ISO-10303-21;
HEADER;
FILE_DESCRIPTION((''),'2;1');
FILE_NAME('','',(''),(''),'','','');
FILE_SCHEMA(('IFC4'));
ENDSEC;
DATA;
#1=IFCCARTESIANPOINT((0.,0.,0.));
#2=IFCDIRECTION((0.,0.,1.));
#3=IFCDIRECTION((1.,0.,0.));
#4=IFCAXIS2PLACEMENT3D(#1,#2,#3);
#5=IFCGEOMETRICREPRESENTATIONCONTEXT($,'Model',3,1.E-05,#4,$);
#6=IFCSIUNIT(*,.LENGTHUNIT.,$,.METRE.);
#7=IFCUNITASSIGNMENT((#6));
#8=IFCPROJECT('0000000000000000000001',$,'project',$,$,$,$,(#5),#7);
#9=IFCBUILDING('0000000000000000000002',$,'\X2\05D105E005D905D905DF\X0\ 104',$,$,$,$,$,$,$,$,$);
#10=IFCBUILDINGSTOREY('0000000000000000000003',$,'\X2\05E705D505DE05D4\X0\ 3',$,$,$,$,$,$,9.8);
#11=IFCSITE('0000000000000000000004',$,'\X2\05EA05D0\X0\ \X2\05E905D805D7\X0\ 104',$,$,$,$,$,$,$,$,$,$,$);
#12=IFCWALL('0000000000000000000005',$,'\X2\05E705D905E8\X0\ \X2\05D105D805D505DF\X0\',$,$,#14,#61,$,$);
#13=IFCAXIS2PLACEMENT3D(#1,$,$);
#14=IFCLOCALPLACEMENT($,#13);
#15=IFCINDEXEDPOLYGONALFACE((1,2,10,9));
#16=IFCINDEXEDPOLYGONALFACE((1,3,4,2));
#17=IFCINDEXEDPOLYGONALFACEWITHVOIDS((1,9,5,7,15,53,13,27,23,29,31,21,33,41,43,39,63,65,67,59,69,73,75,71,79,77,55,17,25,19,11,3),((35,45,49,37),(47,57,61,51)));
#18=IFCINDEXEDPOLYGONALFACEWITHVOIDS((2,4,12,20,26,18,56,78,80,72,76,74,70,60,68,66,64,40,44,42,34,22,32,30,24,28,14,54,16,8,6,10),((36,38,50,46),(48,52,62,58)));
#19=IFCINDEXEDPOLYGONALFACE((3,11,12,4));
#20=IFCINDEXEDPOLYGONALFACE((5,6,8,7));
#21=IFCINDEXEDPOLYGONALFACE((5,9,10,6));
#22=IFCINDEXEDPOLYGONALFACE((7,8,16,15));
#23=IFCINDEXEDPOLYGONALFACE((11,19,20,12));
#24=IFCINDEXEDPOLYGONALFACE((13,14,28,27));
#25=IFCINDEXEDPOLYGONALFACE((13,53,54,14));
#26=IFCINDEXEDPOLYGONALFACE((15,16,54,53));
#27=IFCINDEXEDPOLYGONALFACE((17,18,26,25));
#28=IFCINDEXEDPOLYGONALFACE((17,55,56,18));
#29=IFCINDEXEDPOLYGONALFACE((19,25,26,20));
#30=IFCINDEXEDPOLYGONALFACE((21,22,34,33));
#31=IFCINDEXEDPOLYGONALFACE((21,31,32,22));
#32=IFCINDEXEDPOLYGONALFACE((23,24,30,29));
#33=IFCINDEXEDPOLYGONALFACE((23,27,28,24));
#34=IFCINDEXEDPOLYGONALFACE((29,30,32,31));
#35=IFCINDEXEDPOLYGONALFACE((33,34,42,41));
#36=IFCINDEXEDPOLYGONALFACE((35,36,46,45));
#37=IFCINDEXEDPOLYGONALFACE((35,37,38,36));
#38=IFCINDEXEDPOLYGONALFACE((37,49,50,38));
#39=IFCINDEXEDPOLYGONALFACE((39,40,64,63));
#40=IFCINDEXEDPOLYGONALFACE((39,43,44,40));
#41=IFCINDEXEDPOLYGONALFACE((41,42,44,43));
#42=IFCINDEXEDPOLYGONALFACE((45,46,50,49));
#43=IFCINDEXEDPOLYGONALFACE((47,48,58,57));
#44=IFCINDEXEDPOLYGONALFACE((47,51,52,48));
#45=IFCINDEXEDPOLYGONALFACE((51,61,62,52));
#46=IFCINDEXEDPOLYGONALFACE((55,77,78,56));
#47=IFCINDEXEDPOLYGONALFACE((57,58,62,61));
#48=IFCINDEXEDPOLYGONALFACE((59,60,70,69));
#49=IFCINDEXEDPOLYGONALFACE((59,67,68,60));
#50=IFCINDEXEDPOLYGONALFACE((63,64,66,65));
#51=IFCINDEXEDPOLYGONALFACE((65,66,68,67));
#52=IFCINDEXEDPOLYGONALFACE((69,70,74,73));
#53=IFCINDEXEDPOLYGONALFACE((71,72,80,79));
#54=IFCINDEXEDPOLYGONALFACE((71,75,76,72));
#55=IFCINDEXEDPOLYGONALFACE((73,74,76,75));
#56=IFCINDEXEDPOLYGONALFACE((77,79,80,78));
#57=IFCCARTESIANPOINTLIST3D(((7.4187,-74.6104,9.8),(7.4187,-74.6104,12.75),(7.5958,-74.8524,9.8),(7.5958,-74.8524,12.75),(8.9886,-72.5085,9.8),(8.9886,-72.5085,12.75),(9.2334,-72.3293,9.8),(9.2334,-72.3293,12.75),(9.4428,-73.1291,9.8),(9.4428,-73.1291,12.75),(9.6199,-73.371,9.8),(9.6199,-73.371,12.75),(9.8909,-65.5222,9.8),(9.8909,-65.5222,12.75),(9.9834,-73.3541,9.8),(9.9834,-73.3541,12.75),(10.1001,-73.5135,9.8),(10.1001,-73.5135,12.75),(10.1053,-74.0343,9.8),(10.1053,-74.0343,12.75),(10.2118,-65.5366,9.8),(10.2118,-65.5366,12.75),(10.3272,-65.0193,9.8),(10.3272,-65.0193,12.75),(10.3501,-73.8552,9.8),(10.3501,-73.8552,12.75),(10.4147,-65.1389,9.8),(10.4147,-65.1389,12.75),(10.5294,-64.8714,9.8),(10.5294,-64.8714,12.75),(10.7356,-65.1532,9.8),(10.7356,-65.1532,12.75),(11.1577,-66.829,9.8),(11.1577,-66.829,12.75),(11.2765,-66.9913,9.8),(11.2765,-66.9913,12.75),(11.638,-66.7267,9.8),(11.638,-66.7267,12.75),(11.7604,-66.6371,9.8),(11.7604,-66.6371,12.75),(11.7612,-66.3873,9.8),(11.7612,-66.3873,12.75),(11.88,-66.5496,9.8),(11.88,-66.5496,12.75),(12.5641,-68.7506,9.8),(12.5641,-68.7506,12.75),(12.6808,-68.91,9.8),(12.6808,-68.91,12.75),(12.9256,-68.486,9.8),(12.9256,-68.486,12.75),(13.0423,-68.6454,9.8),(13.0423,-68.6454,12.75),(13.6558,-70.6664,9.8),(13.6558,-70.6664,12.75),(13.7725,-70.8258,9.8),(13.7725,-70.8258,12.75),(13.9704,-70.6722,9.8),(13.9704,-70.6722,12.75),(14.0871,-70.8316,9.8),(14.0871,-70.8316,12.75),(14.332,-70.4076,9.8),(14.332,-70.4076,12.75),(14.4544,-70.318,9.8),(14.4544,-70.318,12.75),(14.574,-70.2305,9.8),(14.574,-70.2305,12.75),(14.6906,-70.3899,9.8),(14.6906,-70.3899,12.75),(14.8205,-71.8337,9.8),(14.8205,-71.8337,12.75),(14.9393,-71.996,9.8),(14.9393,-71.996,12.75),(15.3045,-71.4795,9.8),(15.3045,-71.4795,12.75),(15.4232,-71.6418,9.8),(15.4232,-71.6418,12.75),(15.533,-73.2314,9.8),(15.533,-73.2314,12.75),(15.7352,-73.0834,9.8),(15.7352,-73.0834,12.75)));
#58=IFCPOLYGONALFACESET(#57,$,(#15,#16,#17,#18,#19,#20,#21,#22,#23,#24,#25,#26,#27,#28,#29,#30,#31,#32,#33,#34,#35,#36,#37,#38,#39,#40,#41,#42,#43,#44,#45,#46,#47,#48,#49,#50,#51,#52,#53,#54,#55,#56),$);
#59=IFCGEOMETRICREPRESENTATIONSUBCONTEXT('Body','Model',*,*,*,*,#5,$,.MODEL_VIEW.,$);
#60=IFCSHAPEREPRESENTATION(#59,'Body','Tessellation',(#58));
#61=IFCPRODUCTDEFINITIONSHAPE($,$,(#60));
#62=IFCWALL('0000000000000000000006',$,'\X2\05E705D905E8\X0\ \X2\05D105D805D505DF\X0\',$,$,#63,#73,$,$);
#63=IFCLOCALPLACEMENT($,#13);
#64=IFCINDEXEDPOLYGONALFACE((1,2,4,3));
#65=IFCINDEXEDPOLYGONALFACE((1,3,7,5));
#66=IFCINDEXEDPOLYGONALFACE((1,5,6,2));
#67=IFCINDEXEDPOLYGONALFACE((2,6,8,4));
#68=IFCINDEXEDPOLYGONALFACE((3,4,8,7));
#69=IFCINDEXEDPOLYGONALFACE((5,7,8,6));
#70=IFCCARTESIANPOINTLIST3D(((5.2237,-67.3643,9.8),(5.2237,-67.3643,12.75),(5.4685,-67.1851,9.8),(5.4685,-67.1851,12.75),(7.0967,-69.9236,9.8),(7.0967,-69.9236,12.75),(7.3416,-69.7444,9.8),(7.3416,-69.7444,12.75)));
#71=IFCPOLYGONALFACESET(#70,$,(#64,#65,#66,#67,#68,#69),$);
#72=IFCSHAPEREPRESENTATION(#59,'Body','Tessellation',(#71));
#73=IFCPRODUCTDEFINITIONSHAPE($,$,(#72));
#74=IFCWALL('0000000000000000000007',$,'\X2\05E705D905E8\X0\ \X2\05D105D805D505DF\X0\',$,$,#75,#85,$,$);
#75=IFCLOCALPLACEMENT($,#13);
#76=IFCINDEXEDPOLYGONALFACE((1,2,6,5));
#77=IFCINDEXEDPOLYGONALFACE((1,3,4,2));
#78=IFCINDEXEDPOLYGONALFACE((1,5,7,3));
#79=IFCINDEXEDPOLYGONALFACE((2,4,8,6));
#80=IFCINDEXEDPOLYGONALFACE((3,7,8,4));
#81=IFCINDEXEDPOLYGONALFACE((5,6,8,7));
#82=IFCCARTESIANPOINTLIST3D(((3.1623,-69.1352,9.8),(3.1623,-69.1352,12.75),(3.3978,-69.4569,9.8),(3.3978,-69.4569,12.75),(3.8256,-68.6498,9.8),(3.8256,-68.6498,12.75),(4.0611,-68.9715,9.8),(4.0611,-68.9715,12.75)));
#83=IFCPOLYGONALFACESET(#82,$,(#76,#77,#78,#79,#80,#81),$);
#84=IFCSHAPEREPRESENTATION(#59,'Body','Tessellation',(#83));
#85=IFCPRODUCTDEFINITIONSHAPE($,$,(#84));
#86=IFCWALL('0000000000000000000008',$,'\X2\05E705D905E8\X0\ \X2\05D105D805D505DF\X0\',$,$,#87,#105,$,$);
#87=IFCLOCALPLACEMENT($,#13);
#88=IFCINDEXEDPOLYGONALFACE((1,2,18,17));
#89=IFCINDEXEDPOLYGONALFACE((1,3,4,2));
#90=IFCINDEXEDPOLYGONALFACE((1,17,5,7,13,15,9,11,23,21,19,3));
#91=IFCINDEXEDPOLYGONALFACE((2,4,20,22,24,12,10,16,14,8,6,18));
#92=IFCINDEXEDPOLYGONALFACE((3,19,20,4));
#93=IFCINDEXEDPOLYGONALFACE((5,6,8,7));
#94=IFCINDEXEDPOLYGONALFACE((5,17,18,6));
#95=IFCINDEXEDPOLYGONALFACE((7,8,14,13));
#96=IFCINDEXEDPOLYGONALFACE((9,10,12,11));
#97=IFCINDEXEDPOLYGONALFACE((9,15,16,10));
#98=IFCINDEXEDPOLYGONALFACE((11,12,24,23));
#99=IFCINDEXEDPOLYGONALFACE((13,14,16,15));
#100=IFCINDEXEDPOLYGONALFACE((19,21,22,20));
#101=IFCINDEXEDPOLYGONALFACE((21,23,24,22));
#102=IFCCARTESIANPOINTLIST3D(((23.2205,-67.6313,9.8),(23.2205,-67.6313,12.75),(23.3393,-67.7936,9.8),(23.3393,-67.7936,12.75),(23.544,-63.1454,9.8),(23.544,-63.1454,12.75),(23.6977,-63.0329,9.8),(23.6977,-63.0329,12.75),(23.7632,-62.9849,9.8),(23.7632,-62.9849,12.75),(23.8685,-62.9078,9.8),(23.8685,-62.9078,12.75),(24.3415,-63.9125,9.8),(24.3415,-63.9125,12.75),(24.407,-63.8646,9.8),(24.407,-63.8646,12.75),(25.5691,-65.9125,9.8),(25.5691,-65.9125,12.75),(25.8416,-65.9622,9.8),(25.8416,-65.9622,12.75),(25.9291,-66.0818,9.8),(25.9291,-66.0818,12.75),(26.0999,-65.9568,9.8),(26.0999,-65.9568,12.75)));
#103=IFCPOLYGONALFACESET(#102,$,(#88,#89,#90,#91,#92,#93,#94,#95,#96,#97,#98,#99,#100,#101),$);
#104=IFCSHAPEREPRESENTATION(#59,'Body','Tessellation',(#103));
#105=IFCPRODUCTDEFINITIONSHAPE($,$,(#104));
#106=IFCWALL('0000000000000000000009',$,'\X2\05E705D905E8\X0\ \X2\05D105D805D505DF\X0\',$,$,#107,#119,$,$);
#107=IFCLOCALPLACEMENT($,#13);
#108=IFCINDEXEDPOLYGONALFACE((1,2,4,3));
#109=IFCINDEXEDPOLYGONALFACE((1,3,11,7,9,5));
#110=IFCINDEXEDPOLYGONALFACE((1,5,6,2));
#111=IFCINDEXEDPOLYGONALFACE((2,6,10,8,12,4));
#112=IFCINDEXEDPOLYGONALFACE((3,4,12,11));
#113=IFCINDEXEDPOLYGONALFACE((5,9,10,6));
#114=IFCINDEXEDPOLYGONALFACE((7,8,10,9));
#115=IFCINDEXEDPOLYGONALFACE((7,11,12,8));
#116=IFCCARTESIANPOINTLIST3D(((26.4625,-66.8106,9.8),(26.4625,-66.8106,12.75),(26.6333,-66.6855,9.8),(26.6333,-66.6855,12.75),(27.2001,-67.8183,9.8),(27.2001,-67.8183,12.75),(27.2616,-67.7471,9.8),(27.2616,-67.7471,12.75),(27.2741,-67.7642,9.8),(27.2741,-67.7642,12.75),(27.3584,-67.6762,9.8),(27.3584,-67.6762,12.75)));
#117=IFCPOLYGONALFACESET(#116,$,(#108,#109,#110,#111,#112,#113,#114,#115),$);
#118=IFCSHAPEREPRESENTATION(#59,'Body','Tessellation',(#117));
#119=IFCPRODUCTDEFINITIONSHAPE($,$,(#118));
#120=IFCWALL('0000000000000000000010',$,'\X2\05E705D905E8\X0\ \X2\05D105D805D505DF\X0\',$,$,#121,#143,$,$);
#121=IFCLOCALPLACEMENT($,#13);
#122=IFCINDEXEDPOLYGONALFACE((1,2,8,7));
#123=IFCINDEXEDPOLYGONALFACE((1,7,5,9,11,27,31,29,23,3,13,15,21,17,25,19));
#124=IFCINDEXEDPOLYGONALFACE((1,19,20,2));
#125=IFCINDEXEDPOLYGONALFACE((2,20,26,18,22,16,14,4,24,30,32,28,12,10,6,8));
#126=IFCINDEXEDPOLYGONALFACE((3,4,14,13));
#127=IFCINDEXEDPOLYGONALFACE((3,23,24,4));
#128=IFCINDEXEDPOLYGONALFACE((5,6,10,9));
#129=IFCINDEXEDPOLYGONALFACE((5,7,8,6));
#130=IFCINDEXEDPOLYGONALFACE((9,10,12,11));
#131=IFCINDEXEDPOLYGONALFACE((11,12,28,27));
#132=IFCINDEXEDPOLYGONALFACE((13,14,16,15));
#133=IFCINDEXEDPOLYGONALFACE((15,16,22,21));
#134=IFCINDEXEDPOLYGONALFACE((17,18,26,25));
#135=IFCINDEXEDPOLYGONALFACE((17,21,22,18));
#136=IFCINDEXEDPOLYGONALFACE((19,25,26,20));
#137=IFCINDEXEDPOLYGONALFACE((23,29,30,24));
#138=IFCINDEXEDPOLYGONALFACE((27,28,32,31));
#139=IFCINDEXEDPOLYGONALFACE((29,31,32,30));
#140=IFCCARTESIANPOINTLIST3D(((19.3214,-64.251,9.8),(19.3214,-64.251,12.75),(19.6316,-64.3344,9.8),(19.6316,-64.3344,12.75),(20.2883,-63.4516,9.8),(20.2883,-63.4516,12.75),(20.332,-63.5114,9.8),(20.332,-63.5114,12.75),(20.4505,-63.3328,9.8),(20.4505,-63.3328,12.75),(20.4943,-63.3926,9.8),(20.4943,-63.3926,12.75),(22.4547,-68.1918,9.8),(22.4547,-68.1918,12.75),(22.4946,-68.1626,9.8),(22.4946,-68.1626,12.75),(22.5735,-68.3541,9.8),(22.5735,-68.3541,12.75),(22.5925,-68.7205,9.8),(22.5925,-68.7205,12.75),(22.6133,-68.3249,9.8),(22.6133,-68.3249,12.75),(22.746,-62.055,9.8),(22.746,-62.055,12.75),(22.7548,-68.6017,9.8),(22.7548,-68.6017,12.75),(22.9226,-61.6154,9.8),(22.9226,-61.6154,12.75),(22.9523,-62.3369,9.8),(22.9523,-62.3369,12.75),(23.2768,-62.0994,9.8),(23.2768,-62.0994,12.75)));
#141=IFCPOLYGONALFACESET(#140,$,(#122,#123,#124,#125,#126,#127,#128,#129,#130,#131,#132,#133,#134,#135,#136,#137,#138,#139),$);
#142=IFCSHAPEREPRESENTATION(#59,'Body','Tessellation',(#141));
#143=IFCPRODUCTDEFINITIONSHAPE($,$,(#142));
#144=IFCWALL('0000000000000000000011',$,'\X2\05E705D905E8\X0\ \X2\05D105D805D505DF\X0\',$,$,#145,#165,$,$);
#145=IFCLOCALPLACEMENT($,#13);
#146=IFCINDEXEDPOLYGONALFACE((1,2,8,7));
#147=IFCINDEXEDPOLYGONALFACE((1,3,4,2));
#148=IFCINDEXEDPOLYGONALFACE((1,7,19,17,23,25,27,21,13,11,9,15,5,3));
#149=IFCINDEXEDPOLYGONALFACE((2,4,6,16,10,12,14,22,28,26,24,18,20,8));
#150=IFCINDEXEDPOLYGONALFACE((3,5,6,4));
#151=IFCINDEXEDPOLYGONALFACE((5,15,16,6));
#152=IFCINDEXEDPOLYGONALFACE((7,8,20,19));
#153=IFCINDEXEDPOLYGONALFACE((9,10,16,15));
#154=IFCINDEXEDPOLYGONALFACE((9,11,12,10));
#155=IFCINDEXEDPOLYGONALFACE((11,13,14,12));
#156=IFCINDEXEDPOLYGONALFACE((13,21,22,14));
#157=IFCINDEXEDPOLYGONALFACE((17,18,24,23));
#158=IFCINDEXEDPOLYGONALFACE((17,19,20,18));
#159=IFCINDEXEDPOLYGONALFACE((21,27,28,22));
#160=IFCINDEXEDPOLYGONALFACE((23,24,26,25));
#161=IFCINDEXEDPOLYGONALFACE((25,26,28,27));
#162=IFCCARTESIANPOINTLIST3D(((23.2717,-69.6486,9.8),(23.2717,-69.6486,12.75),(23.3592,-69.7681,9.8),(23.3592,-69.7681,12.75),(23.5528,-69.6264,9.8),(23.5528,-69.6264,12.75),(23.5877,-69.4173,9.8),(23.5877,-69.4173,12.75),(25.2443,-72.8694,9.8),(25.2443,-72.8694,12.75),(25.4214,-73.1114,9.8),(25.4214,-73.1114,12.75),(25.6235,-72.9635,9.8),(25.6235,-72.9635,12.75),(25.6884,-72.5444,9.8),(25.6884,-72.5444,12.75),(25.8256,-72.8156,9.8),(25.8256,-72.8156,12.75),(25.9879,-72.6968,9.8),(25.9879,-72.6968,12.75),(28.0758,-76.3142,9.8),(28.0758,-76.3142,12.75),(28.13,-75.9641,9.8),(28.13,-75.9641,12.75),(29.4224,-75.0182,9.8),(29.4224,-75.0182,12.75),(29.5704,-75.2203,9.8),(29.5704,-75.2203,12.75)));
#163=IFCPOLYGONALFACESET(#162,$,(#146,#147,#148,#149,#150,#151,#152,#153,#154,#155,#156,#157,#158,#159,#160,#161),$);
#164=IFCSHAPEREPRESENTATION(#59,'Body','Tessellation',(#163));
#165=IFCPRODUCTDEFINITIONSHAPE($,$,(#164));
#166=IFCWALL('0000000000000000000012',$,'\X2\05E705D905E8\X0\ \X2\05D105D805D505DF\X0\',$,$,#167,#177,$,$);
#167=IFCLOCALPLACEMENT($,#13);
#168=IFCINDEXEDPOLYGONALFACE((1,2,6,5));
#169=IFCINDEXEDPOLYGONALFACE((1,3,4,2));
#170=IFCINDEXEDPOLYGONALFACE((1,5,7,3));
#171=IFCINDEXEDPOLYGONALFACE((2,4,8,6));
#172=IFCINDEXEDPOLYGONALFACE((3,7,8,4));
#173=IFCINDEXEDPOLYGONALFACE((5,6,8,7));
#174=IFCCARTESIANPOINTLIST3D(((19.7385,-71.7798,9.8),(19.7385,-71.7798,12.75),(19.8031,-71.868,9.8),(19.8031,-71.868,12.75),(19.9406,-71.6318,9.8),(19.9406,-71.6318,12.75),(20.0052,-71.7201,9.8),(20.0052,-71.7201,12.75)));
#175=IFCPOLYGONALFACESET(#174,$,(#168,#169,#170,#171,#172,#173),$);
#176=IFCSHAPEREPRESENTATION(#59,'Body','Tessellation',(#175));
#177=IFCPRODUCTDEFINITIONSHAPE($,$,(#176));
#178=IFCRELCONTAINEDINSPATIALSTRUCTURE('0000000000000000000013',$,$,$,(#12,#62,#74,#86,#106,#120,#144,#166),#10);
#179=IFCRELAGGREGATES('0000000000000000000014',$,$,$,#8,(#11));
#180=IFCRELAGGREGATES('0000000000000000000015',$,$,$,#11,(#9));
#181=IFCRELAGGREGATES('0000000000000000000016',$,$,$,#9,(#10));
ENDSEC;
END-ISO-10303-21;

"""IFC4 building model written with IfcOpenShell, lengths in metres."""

from ifc_helpers import new_model, si_unit, frame, origin_with_axes, context, subcontext, project, spatial, polyline, outline, extrude, element, save


model = new_model("IFC4")

# Units and contexts
model_context = context("Model", 3, precision=1e-05, world=origin_with_axes())
body_context = subcontext(model_context, "Body", "Model", "MODEL_VIEW")
ifc_project = project(units=[si_unit("LENGTHUNIT", "METRE")], contexts=[model_context])

# Site, building, storey
site = spatial("IfcSite", under=ifc_project, Name="תא שטח 104")
building = spatial("IfcBuilding", under=site, Name="בניין 104")
storey = spatial("IfcBuildingStorey", under=building, Name="קומה 3", Elevation=9.8)

# Walls
element("IfcWall", 1, inside=storey, Name="קיר בטון", context=body_context, shape_type="SweptSolid", body=[
    extrude(outline(polyline([(11.7604, -66.6371), (11.88, -66.5496), (11.7612, -66.3873), (11.1577, -66.829), (10.2118, -65.5366), (10.7356, -65.1532), (10.5294, -64.8714), (10.3272, -65.0193), (10.4147, -65.1389), (9.8909, -65.5222), (13.6558, -70.6664), (9.9834, -73.3541), (9.2334, -72.3293), (8.9886, -72.5085), (9.4428, -73.1291), (7.4187, -74.6104), (7.5958, -74.8524), (9.6199, -73.371), (10.1053, -74.0343), (10.3501, -73.8552), (10.1001, -73.5135), (13.7725, -70.8258), (15.533, -73.2314), (15.7352, -73.0834), (14.9393, -71.996), (15.4232, -71.6418), (15.3045, -71.4795), (14.8205, -71.8337), (14.0871, -70.8316), (14.6906, -70.3899), (14.574, -70.2305), (14.4544, -70.318), (11.7604, -66.6371)]), holes=[polyline([(11.638, -66.7267), (12.9256, -68.486), (12.5641, -68.7506), (11.2765, -66.9913), (11.638, -66.7267)]), polyline([(14.332, -70.4076), (13.9704, -70.6722), (12.6808, -68.91), (13.0423, -68.6454), (14.332, -70.4076)])]), frame((0.0, 0.0, 9.8)), (0.0, 0.0, 1.0), 2.95),
])
element("IfcWall", 2, inside=storey, Name="קיר בטון", context=body_context, shape_type="SweptSolid", body=[
    extrude(outline(polyline([(5.4685, -67.1851), (5.2237, -67.3643), (7.0967, -69.9236), (7.3416, -69.7444), (5.4685, -67.1851)])), frame((0.0, 0.0, 9.8)), (0.0, 0.0, 1.0), 2.95),
])
element("IfcWall", 3, inside=storey, Name="קיר בטון", context=body_context, shape_type="SweptSolid", body=[
    extrude(outline(polyline([(3.1623, -69.1352), (3.3978, -69.4569), (4.0611, -68.9715), (3.8256, -68.6498), (3.1623, -69.1352)])), frame((0.0, 0.0, 9.8)), (0.0, 0.0, 1.0), 2.95),
])
element("IfcWall", 4, inside=storey, Name="קיר בטון", context=body_context, shape_type="SweptSolid", body=[
    extrude(outline(polyline([(24.407, -63.8646), (24.3415, -63.9125), (23.6977, -63.0329), (23.544, -63.1454), (25.5691, -65.9125), (23.2205, -67.6313), (23.3393, -67.7936), (25.8416, -65.9622), (25.9291, -66.0818), (26.0999, -65.9568), (23.8685, -62.9078), (23.7632, -62.9849), (24.407, -63.8646)])), frame((0.0, 0.0, 9.8)), (0.0, 0.0, 1.0), 2.95),
])
element("IfcWall", 5, inside=storey, Name="קיר בטון", context=body_context, shape_type="SweptSolid", body=[
    extrude(outline(polyline([(26.4625, -66.8106), (27.2001, -67.8183), (27.2741, -67.7642), (27.2616, -67.7471), (27.3584, -67.6762), (26.6333, -66.6855), (26.4625, -66.8106)])), frame((0.0, 0.0, 9.8)), (0.0, 0.0, 1.0), 2.95),
])
element("IfcWall", 6, inside=storey, Name="קיר בטון", context=body_context, shape_type="SweptSolid", body=[
    extrude(outline(polyline([(20.332, -63.5114), (19.3214, -64.251), (22.5925, -68.7205), (22.7548, -68.6017), (22.5735, -68.3541), (22.6133, -68.3249), (22.4946, -68.1626), (22.4547, -68.1918), (19.6316, -64.3344), (22.746, -62.055), (22.9523, -62.3369), (23.2768, -62.0994), (22.9226, -61.6154), (20.4943, -63.3926), (20.4505, -63.3328), (20.2883, -63.4516), (20.332, -63.5114)])), frame((0.0, 0.0, 9.8)), (0.0, 0.0, 1.0), 2.95),
])
element("IfcWall", 7, inside=storey, Name="קיר בטון", context=body_context, shape_type="SweptSolid", body=[
    extrude(outline(polyline([(23.2717, -69.6486), (23.3592, -69.7681), (23.5528, -69.6264), (25.6884, -72.5444), (25.2443, -72.8694), (25.4214, -73.1114), (25.6235, -72.9635), (28.0758, -76.3142), (29.5704, -75.2203), (29.4224, -75.0182), (28.13, -75.9641), (25.8256, -72.8156), (25.9879, -72.6968), (23.5877, -69.4173), (23.2717, -69.6486)])), frame((0.0, 0.0, 9.8)), (0.0, 0.0, 1.0), 2.95),
])
element("IfcWall", 8, inside=storey, Name="קיר בטון", context=body_context, shape_type="SweptSolid", body=[
    extrude(outline(polyline([(19.7385, -71.7798), (19.8031, -71.868), (20.0052, -71.7201), (19.9406, -71.6318), (19.7385, -71.7798)])), frame((0.0, 0.0, 9.8)), (0.0, 0.0, 1.0), 2.95),
])

save(model, "model.ifc")
